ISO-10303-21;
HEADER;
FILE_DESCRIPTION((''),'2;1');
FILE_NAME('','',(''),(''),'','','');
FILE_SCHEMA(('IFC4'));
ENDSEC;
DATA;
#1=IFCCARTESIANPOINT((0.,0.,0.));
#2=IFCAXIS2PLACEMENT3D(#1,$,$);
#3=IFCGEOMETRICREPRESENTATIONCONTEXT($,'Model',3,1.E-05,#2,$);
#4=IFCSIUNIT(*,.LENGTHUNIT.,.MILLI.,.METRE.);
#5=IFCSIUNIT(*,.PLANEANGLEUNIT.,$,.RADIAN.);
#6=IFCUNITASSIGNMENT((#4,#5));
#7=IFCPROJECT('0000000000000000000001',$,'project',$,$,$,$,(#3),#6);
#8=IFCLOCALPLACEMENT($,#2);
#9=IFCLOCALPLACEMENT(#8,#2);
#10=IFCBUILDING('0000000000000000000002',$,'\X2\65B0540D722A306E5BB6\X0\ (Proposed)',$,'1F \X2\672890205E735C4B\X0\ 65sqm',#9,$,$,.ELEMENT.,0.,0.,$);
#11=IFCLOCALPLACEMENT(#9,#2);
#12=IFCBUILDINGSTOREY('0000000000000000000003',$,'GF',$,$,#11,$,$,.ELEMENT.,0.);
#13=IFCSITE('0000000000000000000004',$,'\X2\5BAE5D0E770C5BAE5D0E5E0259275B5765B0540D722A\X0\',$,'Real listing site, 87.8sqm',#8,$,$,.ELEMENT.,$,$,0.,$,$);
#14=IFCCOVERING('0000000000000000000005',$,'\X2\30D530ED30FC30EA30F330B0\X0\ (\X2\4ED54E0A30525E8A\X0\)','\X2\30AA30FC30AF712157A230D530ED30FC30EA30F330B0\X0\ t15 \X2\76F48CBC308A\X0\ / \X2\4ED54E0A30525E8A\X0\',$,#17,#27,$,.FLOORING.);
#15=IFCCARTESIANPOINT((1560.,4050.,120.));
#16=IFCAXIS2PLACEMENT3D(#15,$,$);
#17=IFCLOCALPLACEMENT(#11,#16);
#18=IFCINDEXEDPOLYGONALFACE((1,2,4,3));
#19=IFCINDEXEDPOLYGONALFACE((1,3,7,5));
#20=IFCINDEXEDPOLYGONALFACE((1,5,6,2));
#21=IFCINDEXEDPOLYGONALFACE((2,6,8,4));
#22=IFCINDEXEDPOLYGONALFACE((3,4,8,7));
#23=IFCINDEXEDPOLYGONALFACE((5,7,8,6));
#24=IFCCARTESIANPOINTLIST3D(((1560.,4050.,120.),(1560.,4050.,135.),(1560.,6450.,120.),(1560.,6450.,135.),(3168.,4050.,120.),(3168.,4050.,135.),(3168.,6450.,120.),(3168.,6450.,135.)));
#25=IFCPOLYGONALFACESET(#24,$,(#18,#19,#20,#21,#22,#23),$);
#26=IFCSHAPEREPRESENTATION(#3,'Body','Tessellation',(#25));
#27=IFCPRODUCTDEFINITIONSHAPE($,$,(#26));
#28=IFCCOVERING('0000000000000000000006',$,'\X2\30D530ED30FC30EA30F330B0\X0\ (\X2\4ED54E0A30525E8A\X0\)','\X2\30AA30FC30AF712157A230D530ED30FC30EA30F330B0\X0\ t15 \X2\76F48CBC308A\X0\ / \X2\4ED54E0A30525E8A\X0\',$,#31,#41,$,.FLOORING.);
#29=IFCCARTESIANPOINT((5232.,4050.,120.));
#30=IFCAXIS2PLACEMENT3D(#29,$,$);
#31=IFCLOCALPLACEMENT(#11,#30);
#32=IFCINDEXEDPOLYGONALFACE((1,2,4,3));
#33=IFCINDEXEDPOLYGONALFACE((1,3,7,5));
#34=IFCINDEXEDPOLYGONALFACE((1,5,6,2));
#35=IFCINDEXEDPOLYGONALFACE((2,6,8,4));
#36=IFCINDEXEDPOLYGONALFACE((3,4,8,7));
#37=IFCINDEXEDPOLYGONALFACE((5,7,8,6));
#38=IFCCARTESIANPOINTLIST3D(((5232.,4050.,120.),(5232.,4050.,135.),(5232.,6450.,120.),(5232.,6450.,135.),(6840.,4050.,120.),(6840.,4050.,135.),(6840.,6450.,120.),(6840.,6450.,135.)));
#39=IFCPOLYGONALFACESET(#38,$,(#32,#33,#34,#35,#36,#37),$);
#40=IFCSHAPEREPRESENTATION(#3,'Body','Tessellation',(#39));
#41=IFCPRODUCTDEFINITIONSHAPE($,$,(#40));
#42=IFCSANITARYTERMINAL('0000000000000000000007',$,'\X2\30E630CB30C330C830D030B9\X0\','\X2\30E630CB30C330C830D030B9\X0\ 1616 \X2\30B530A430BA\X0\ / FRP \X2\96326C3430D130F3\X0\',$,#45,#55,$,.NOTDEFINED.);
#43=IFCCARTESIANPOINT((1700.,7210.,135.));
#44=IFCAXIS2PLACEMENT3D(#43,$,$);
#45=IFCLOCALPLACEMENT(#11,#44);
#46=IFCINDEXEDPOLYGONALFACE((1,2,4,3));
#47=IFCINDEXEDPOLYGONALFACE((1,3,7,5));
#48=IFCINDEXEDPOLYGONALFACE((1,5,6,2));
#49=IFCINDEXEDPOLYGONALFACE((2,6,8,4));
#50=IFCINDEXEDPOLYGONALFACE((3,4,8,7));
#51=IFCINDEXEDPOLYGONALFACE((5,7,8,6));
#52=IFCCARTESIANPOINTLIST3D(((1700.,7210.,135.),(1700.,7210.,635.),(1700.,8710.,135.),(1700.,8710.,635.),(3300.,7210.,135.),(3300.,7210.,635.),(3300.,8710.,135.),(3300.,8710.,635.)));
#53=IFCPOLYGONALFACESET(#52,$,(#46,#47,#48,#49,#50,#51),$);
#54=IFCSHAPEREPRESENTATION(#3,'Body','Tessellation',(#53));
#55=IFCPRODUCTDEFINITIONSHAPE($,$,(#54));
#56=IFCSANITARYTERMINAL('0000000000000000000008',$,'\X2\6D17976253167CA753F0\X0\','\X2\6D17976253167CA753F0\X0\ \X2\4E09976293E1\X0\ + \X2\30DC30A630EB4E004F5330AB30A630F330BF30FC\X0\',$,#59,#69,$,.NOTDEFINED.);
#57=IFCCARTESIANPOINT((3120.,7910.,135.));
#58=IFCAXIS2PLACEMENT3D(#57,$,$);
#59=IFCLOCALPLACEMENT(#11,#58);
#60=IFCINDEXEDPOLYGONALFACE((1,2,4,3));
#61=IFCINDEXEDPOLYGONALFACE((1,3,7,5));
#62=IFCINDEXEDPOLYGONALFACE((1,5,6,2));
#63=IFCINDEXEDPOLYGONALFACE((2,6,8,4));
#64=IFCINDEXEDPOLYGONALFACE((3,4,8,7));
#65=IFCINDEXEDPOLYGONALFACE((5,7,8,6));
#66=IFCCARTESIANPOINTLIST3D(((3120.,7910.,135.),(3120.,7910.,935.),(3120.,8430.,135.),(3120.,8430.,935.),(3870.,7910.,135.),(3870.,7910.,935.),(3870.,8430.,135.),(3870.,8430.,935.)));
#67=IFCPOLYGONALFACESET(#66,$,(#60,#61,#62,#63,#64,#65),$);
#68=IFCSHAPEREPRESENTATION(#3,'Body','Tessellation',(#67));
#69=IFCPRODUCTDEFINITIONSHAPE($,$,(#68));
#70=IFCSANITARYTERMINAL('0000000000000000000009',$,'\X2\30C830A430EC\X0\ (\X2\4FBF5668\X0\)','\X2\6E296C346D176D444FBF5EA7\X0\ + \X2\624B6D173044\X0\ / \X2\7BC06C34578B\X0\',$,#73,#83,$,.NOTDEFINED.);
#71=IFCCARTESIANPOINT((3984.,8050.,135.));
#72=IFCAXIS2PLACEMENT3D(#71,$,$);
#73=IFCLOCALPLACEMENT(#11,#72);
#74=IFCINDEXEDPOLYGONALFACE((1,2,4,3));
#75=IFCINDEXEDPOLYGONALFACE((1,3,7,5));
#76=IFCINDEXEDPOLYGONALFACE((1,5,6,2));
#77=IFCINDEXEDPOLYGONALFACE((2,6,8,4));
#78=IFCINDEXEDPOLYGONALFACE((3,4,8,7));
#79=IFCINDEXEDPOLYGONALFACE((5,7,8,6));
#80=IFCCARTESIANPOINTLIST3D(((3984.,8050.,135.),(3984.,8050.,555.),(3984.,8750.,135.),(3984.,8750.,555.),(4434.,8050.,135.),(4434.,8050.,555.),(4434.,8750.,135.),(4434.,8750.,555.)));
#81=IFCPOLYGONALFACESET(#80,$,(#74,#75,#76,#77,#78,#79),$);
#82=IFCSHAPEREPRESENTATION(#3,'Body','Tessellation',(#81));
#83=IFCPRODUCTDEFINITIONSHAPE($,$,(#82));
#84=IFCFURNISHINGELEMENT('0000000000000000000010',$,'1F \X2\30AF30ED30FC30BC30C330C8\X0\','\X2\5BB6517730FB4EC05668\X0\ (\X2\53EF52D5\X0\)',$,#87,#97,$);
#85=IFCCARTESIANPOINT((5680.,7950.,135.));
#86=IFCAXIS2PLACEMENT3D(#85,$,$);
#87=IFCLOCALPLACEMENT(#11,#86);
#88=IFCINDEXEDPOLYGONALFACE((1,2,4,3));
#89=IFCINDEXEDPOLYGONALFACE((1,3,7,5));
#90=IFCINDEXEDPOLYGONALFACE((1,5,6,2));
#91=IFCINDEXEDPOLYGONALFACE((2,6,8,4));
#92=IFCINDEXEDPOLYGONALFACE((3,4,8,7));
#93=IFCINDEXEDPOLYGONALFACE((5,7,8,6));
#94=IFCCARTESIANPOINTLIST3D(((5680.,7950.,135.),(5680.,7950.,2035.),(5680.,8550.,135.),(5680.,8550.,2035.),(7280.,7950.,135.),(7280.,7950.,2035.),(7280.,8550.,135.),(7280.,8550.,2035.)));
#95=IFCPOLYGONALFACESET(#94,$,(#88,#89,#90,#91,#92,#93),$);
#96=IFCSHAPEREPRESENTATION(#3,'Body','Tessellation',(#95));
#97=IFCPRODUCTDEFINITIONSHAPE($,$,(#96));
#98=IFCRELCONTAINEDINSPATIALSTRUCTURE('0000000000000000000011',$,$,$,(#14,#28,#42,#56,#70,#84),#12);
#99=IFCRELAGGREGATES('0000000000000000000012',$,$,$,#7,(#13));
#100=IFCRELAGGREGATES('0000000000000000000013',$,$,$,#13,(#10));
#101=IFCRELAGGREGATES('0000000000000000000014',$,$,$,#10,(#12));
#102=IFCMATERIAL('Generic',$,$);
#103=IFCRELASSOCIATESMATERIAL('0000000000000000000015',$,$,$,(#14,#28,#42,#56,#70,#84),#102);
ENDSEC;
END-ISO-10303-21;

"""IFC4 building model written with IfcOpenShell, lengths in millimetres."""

from ifc_helpers import new_model, si_unit, frame, frame_2d, origin, place, context, project, spatial, rectangle, extrude, material, element, save


model = new_model("IFC4")

# Units and contexts
model_context = context("Model", 3, precision=1e-05, world=origin())
ifc_project = project(units=[si_unit("LENGTHUNIT", "METRE", prefix="MILLI"), si_unit("PLANEANGLEUNIT", "RADIAN")], contexts=[model_context])

# Site, building, storey
site_placement = place(None, origin())
site = spatial("IfcSite", under=ifc_project, at=site_placement, Name="宮崎県宮崎市大字新名爪", ObjectType="Real listing site, 87.8sqm", CompositionType="ELEMENT", RefElevation=0.0)
building_placement = place(site_placement, origin())
building = spatial("IfcBuilding", under=site, at=building_placement, Name="新名爪の家 (Proposed)", ObjectType="1F 木造平屋 65sqm", CompositionType="ELEMENT", ElevationOfRefHeight=0.0, ElevationOfTerrain=0.0)
storey_placement = place(building_placement, origin())
storey = spatial("IfcBuildingStorey", under=building, at=storey_placement, Name="GF", CompositionType="ELEMENT", Elevation=0.0)

# Coverings
ifc_material_1 = material(Name="Generic")
covering_1_placement = place(storey_placement, frame((1560.0, 4050.0, 120.0)))
element("IfcCovering", 1, at=covering_1_placement, inside=storey, material=ifc_material_1, Name="フローリング (仕上げ床)", Description="オーク無垢フローリング t15 直貼り / 仕上げ床", PredefinedType="FLOORING", context=model_context, shape_type="SweptSolid", body=[
    extrude(rectangle(XDim=1608.0, YDim=2400.0, at=frame_2d((804.0, 1200.0))), frame((1560.0, 4050.0, 120.0)), (0.0, 0.0, 1.0), 15.0),
])
covering_2_placement = place(storey_placement, frame((5232.0, 4050.0, 120.0)))
element("IfcCovering", 2, at=covering_2_placement, inside=storey, material=ifc_material_1, Name="フローリング (仕上げ床)", Description="オーク無垢フローリング t15 直貼り / 仕上げ床", PredefinedType="FLOORING", context=model_context, shape_type="SweptSolid", body=[
    extrude(rectangle(XDim=1608.0, YDim=2400.0, at=frame_2d((804.0, 1200.0))), frame((5232.0, 4050.0, 120.0)), (0.0, 0.0, 1.0), 15.0),
])

# Sanitary terminals
sanitary_terminal_1_placement = place(storey_placement, frame((1700.0, 7210.0, 135.0)))
element("IfcSanitaryTerminal", 3, at=sanitary_terminal_1_placement, inside=storey, material=ifc_material_1, Name="ユニットバス", Description="ユニットバス 1616 サイズ / FRP 防水パン", PredefinedType="NOTDEFINED", context=model_context, shape_type="SweptSolid", body=[
    extrude(rectangle(XDim=1600.0, YDim=1500.0, at=frame_2d((800.0, 750.0))), frame((1700.0, 7210.0, 135.0)), (0.0, 0.0, 1.0), 500.0),
])
sanitary_terminal_2_placement = place(storey_placement, frame((3120.0, 7910.0, 135.0)))
element("IfcSanitaryTerminal", 4, at=sanitary_terminal_2_placement, inside=storey, material=ifc_material_1, Name="洗面化粧台", Description="洗面化粧台 三面鏡 + ボウル一体カウンター", PredefinedType="NOTDEFINED", context=model_context, shape_type="SweptSolid", body=[
    extrude(rectangle(XDim=750.0, YDim=520.0, at=frame_2d((375.0, 260.0))), frame((3120.0, 7910.0, 135.0)), (0.0, 0.0, 1.0), 800.0),
])
sanitary_terminal_3_placement = place(storey_placement, frame((3984.0, 8050.0, 135.0)))
element("IfcSanitaryTerminal", 5, at=sanitary_terminal_3_placement, inside=storey, material=ifc_material_1, Name="トイレ (便器)", Description="温水洗浄便座 + 手洗い / 節水型", PredefinedType="NOTDEFINED", context=model_context, shape_type="SweptSolid", body=[
    extrude(rectangle(XDim=450.0, YDim=700.0, at=frame_2d((225.0, 350.0))), frame((3984.0, 8050.0, 135.0)), (0.0, 0.0, 1.0), 420.0),
])

# Furnishing element
furnishing_placement = place(storey_placement, frame((5680.0, 7950.0, 135.0)))
element("IfcFurnishingElement", 6, at=furnishing_placement, inside=storey, material=ifc_material_1, Name="1F クローゼット", Description="家具・什器 (可動)", context=model_context, shape_type="SweptSolid", body=[
    extrude(rectangle(XDim=1600.0, YDim=600.0, at=frame_2d((800.0, 300.0))), frame((5680.0, 7950.0, 135.0)), (0.0, 0.0, 1.0), 1900.0),
])

save(model, "model.ifc")
